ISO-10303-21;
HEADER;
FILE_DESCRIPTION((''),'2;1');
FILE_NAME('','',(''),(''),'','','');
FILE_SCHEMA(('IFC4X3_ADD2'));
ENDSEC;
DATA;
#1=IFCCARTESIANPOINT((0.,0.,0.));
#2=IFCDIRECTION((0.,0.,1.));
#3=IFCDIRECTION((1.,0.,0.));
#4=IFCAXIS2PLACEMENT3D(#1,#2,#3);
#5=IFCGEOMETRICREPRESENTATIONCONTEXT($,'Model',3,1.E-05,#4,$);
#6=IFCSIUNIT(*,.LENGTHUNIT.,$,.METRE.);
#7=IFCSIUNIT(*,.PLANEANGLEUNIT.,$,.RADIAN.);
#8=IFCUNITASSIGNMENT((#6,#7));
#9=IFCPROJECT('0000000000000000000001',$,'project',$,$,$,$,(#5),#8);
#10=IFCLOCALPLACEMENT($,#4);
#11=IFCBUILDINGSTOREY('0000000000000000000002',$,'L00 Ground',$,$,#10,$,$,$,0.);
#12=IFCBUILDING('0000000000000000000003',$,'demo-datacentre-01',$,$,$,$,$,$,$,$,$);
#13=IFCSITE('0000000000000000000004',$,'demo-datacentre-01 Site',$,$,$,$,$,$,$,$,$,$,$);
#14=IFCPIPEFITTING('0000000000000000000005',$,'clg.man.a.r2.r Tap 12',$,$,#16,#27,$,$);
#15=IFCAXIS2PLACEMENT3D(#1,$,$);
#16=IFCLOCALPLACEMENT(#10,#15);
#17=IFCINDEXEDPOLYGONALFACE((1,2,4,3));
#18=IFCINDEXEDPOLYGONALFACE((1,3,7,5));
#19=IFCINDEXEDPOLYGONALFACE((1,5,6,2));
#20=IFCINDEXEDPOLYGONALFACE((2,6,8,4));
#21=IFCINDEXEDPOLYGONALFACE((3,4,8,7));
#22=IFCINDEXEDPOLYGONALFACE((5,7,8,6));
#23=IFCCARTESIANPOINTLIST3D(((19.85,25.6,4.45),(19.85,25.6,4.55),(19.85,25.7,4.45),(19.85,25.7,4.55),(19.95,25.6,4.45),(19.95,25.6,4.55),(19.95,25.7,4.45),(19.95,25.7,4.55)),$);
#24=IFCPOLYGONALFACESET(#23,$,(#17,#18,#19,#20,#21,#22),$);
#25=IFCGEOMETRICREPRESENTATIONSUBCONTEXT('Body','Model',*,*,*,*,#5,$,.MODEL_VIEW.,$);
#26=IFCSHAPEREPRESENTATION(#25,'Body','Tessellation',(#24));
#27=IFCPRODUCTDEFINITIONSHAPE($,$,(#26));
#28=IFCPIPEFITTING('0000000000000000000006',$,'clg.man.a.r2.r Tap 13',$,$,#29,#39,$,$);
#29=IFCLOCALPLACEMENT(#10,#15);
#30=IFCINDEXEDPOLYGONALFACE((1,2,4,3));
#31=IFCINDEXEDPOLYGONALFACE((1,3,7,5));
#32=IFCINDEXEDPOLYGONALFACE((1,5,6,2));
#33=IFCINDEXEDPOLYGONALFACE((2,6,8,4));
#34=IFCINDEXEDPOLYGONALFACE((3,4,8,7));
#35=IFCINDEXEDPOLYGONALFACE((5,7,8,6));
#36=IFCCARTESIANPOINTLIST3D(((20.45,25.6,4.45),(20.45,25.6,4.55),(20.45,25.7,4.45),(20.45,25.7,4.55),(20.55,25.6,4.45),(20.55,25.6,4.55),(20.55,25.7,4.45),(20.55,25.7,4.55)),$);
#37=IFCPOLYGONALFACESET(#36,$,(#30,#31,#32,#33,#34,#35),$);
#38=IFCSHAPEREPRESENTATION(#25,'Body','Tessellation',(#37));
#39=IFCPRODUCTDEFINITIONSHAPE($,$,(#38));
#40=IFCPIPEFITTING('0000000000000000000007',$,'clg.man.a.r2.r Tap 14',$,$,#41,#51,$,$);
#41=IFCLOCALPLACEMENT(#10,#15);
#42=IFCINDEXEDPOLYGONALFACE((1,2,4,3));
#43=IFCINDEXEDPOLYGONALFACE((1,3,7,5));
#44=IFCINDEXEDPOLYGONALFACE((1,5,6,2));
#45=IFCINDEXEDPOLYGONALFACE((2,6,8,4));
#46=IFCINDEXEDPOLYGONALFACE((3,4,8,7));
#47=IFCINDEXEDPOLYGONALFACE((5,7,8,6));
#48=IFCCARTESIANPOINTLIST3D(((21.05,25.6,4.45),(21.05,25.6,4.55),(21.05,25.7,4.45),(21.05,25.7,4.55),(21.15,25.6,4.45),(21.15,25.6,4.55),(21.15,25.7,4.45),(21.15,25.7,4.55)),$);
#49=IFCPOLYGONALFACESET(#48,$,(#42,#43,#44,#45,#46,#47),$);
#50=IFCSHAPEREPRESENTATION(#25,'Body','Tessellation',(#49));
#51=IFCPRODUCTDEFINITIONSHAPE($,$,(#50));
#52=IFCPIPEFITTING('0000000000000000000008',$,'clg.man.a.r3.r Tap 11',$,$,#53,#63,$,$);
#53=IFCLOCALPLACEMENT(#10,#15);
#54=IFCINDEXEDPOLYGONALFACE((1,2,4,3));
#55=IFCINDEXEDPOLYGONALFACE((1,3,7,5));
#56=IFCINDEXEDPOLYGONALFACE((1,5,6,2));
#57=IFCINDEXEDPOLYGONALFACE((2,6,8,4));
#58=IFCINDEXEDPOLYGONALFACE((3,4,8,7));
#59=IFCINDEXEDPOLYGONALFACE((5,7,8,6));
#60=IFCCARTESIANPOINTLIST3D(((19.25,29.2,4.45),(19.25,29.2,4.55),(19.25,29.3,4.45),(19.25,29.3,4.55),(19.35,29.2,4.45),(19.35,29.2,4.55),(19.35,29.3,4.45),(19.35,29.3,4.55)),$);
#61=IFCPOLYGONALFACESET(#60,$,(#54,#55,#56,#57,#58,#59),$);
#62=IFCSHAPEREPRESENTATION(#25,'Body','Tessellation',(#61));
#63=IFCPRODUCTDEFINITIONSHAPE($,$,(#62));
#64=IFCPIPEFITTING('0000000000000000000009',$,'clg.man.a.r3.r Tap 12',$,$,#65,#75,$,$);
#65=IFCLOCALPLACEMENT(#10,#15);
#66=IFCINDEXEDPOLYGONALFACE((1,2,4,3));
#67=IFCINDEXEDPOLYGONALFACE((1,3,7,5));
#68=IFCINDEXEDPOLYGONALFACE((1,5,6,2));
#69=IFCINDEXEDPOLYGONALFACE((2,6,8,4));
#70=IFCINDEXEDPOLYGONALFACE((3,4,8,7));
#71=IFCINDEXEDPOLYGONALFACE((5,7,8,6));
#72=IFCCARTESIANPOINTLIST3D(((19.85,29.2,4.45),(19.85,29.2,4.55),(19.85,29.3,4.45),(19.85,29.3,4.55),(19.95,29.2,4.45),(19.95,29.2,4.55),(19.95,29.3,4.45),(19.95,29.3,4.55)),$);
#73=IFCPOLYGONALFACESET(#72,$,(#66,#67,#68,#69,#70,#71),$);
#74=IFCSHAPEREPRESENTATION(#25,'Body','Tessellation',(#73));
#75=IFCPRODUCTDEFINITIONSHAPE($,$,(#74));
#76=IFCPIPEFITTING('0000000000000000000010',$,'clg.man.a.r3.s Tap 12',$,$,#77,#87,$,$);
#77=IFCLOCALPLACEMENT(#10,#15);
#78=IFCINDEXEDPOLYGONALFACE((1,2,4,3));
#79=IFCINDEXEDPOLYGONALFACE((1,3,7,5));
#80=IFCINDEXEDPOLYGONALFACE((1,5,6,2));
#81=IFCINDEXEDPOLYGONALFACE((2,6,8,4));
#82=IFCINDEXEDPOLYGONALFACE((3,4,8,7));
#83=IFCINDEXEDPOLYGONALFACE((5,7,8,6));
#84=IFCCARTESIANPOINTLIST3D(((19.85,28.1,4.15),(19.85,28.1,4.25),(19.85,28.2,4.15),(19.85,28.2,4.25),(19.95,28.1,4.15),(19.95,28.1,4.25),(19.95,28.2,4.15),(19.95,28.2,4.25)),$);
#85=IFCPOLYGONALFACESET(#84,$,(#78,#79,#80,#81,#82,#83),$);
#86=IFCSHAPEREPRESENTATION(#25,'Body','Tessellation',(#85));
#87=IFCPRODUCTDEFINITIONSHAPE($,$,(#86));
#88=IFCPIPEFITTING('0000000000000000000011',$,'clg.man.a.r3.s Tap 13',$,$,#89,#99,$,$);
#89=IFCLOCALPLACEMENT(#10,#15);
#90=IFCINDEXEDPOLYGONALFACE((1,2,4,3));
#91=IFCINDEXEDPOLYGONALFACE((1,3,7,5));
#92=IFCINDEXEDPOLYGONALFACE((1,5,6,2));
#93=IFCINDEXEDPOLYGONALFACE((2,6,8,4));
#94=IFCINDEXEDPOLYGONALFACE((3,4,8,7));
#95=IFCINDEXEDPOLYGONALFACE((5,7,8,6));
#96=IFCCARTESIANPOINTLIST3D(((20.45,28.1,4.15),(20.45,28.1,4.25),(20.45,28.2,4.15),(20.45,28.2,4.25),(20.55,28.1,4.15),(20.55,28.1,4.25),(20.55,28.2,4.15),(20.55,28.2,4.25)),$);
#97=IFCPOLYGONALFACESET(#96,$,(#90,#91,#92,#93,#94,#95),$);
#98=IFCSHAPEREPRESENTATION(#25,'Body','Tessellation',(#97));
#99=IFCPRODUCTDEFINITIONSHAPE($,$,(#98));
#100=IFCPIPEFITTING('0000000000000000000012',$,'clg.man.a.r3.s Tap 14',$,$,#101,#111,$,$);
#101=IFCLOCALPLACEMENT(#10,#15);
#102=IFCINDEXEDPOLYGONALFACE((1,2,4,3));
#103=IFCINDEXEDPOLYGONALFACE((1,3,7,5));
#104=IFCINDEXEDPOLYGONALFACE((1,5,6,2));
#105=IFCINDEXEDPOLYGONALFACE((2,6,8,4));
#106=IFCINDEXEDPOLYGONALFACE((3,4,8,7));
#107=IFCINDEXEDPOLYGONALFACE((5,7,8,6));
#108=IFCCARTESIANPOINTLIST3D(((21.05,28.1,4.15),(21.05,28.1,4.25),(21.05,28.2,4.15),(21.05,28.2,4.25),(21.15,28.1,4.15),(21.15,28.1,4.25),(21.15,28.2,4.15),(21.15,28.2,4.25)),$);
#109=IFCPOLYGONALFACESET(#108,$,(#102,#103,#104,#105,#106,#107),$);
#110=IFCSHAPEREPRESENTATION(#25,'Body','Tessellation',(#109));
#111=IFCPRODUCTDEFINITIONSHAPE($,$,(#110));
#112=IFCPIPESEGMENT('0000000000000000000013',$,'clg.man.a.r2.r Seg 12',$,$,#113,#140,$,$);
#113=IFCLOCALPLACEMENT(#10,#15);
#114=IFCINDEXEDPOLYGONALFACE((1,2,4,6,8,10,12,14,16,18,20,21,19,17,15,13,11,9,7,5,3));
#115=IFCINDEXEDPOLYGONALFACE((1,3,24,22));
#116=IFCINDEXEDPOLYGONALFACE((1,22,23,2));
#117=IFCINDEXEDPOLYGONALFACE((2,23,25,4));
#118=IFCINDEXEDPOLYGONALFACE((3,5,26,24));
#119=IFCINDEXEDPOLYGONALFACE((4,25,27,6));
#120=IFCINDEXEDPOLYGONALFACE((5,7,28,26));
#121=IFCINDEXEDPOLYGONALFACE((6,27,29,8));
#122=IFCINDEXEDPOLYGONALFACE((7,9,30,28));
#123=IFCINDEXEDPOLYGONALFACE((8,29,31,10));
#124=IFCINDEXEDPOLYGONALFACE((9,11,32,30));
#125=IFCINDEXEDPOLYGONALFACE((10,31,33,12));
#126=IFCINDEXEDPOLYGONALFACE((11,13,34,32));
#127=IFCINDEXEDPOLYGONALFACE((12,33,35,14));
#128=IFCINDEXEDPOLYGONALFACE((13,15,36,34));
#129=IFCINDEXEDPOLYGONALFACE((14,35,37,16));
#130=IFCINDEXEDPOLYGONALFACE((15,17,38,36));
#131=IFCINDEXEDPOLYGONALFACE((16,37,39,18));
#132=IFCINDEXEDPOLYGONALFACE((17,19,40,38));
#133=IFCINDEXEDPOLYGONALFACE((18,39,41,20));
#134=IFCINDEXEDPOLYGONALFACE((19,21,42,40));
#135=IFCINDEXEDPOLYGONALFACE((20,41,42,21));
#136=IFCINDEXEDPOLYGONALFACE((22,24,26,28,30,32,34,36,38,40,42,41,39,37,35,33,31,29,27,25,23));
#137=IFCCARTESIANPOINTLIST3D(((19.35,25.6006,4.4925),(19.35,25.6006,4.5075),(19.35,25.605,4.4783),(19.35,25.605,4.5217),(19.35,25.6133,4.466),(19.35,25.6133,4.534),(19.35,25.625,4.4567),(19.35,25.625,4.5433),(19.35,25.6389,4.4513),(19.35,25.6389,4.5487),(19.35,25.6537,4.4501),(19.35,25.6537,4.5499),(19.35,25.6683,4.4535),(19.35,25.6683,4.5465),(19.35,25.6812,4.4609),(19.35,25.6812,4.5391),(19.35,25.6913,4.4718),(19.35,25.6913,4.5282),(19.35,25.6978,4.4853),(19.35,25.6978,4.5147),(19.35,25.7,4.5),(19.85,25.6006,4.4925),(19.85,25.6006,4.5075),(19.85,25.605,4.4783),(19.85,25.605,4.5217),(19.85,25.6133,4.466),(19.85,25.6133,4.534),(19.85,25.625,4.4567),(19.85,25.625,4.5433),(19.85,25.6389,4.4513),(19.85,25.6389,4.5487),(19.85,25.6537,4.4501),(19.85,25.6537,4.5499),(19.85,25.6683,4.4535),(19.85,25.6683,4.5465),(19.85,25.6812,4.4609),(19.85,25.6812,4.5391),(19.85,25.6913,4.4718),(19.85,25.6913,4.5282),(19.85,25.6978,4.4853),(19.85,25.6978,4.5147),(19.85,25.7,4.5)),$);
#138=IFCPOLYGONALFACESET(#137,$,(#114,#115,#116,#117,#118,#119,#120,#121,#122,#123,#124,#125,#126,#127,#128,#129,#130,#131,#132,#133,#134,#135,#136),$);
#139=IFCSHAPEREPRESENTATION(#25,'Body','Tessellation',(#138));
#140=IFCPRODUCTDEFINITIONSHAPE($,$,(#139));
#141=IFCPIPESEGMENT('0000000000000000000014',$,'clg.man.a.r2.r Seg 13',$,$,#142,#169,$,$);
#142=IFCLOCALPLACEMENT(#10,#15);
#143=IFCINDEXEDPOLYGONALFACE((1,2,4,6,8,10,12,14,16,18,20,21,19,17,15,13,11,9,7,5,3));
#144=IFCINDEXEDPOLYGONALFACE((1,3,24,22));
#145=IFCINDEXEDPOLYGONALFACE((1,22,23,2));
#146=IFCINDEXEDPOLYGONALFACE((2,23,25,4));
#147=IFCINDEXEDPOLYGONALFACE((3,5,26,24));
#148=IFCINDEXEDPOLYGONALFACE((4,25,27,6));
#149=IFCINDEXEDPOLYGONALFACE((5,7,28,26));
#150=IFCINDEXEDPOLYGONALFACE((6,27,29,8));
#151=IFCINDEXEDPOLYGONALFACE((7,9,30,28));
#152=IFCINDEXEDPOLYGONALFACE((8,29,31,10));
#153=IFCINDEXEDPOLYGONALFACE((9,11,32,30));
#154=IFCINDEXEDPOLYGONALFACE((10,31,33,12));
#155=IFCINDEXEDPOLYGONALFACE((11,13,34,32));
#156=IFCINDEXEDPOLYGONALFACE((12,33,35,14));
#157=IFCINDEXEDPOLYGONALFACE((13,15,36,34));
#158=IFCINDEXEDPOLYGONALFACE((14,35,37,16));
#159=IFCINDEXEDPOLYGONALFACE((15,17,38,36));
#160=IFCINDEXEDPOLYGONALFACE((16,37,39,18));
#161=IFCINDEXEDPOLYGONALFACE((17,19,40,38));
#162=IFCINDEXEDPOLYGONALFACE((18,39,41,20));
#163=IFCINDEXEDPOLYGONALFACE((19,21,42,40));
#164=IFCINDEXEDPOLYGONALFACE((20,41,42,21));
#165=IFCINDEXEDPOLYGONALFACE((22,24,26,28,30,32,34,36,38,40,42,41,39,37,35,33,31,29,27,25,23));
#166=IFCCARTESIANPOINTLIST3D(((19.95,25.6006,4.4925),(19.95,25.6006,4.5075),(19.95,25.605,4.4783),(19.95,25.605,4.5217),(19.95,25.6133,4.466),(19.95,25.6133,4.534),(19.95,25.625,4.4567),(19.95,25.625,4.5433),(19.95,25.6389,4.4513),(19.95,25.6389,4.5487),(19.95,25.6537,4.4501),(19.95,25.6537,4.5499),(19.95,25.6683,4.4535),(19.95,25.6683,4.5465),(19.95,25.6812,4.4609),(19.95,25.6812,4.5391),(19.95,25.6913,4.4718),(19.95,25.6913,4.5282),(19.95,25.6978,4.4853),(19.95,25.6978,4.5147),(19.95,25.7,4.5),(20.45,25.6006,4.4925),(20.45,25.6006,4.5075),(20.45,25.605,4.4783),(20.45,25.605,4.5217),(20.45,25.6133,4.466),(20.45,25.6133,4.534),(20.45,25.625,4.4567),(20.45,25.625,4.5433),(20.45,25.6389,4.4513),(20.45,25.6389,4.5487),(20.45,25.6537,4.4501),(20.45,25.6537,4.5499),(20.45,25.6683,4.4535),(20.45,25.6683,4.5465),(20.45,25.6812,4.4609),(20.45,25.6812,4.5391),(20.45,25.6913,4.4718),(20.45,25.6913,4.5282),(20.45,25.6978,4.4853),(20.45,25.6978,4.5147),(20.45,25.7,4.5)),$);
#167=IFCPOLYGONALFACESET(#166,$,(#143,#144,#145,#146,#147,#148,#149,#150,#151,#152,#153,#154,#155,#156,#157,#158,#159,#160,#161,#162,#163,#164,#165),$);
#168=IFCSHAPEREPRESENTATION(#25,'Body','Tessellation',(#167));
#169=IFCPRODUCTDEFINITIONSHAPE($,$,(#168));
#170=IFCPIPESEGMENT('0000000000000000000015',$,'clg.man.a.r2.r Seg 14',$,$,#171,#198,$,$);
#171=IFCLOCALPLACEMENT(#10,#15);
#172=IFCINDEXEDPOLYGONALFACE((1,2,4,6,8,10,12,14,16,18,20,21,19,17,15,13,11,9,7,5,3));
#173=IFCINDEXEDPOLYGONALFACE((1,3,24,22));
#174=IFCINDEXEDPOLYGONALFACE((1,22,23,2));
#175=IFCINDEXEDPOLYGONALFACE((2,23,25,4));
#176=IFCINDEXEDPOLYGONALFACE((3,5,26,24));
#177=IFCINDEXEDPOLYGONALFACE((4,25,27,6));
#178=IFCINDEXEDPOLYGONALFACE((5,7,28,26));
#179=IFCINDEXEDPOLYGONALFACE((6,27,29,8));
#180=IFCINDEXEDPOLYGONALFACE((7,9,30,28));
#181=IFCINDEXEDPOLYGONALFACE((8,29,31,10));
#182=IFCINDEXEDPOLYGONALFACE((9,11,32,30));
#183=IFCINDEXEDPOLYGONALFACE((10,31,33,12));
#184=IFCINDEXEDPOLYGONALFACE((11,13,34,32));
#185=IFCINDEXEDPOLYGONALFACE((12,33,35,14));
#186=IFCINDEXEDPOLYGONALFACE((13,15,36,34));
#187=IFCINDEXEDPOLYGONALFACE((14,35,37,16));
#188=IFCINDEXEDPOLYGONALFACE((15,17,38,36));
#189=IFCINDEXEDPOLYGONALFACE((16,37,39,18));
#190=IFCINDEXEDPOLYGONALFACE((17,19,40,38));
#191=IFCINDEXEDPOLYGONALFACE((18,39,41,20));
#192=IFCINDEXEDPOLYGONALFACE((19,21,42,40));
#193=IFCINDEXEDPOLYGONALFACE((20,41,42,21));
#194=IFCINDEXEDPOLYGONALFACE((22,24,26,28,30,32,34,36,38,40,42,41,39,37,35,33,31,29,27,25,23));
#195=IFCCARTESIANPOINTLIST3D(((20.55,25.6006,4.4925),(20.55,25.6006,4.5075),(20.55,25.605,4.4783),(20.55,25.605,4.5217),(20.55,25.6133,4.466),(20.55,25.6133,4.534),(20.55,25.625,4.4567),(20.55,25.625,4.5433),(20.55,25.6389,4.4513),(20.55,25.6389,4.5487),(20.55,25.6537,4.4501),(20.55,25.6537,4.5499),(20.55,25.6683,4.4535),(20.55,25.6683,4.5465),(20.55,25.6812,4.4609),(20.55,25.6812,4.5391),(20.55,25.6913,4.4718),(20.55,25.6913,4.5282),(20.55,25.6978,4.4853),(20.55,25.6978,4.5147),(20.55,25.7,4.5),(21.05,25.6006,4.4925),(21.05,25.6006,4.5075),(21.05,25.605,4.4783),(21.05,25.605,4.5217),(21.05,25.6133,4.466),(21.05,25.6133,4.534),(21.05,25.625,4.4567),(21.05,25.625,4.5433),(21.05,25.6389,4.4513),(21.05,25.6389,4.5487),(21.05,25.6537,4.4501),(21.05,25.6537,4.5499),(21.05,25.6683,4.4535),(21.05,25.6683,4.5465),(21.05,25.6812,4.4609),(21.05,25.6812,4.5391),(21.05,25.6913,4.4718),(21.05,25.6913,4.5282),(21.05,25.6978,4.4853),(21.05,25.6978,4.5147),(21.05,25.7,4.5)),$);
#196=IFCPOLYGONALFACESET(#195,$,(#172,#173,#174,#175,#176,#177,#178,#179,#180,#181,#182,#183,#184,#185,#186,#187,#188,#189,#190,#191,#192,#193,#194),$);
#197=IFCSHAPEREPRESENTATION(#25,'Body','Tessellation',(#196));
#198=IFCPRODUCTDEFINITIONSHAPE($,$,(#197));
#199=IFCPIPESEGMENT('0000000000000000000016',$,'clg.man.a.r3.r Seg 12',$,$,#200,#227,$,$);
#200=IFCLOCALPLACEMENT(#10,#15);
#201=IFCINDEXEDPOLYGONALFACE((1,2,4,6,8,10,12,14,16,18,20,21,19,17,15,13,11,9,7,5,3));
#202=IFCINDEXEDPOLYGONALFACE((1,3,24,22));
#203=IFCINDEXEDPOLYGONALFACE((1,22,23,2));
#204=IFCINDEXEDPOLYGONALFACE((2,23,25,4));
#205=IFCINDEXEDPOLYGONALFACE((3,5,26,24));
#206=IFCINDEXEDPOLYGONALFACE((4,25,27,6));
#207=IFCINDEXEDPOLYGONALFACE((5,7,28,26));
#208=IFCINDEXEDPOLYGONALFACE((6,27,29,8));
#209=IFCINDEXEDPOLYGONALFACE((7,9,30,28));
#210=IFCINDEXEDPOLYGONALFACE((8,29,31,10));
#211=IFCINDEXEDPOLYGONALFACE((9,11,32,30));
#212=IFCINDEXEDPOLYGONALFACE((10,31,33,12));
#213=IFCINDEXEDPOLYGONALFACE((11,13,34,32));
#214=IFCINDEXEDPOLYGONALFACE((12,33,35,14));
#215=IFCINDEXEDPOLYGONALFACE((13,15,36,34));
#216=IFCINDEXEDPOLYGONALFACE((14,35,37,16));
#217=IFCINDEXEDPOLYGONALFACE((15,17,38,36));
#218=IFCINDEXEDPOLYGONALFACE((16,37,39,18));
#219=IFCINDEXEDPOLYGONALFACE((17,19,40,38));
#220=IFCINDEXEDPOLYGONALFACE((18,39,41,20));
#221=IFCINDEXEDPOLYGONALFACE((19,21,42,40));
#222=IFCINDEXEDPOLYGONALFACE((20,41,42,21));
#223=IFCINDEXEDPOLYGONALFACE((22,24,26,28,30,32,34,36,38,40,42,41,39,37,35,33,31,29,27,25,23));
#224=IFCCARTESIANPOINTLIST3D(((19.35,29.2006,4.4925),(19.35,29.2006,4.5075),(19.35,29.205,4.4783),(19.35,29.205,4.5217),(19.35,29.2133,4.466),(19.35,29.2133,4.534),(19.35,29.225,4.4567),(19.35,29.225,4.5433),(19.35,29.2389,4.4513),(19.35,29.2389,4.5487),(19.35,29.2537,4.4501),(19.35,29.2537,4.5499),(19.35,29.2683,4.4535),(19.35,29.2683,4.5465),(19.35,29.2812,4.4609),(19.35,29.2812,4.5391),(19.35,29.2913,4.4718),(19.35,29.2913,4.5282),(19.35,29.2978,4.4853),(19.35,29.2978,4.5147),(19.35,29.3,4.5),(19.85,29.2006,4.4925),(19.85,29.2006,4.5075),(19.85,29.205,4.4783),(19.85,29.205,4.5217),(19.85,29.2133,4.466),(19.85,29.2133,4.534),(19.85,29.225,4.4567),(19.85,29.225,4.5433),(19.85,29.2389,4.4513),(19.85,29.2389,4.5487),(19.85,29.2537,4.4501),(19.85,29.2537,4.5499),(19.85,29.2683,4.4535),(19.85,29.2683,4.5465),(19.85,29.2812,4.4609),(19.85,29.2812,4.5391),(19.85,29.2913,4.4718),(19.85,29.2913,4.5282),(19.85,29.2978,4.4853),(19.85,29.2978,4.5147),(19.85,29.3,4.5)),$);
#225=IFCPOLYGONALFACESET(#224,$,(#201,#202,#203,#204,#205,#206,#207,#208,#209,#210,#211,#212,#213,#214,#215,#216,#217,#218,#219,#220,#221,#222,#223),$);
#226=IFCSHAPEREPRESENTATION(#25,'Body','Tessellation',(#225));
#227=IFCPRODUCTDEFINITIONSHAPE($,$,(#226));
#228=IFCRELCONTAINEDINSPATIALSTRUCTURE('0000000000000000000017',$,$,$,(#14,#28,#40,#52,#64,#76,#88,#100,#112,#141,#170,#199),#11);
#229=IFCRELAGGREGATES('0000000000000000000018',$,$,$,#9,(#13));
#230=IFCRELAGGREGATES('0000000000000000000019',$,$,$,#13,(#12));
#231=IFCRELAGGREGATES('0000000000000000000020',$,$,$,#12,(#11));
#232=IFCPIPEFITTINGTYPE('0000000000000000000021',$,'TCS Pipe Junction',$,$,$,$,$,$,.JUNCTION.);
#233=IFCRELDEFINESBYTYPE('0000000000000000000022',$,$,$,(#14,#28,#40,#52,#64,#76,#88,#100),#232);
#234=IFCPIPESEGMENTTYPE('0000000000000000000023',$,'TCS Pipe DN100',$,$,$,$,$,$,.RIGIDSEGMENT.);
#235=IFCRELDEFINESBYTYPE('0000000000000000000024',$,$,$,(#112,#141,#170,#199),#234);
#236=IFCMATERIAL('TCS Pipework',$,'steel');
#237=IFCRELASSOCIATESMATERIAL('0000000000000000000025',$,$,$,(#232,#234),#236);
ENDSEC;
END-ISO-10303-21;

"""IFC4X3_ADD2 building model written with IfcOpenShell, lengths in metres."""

from ifc_helpers import new_model, si_unit, frame, origin_with_axes, place, context, subcontext, project, spatial, rectangle, circle, extrude, material, type_object, element, save


model = new_model("IFC4X3_ADD2")

# Units and contexts
model_context = context("Model", 3, precision=1e-05, world=origin_with_axes())
body_context = subcontext(model_context, "Body", "Model", "MODEL_VIEW")
ifc_project = project(units=[si_unit("LENGTHUNIT", "METRE"), si_unit("PLANEANGLEUNIT", "RADIAN")], contexts=[model_context])

# Site, building, storey
site = spatial("IfcSite", under=ifc_project, Name="demo-datacentre-01 Site")
building = spatial("IfcBuilding", under=site, Name="demo-datacentre-01")
storey_placement = place(None, origin_with_axes())
storey = spatial("IfcBuildingStorey", under=building, at=storey_placement, Name="L00 Ground", Elevation=0.0)

# Pipe fittings
ifc_material = material(Name="TCS Pipework", Category="steel")
pipe_fitting_type = type_object("IfcPipeFittingType", Name="TCS Pipe Junction", PredefinedType="JUNCTION", material=ifc_material)
for number, where, z_axis, x_axis, name in (
    (1, (19.9, 25.65, 4.45), (0.0, 0.0, 1.0), (1.0, 0.0, 0.0), "clg.man.a.r2.r Tap 12"),
    (2, (20.5, 25.65, 4.45), (0.0, 0.0, 1.0), (1.0, 0.0, 0.0), "clg.man.a.r2.r Tap 13"),
    (3, (21.1, 25.65, 4.45), (0.0, 0.0, 1.0), (1.0, 0.0, 0.0), "clg.man.a.r2.r Tap 14"),
    (4, (19.3, 29.25, 4.45), (0.0, 0.0, 1.0), (1.0, 0.0, 0.0), "clg.man.a.r3.r Tap 11"),
    (5, (19.9, 29.25, 4.45), (0.0, 0.0, 1.0), (1.0, 0.0, 0.0), "clg.man.a.r3.r Tap 12"),
    (6, (19.9, 28.15, 4.15), (0.0, 0.0, 1.0), (1.0, 0.0, 0.0), "clg.man.a.r3.s Tap 12"),
    (7, (20.5, 28.15, 4.15), (0.0, 0.0, 1.0), (1.0, 0.0, 0.0), "clg.man.a.r3.s Tap 13"),
    (8, (21.1, 28.15, 4.15), (0.0, 0.0, 1.0), (1.0, 0.0, 0.0), "clg.man.a.r3.s Tap 14"),
):
    element("IfcPipeFitting", number, at=place(storey_placement, frame(where, z_axis=z_axis, x_axis=x_axis)), inside=storey, type_object=pipe_fitting_type, Name=name, context=body_context, shape_type="SweptSolid", body=[
        extrude(rectangle(XDim=0.1, YDim=0.1), origin_with_axes(), (0.0, 0.0, 1.0), 0.1),
    ])

# Pipe segments
pipe_segment_type_1 = type_object("IfcPipeSegmentType", Name="TCS Pipe DN100", PredefinedType="RIGIDSEGMENT", material=ifc_material)
pipe_segment_placement = place(storey_placement, frame((19.35, 25.65, 4.5), z_axis=(1.0, 0.0, 0.0), x_axis=(0.0, 1.0, 0.0)))
element("IfcPipeSegment", 9, at=pipe_segment_placement, inside=storey, type_object=pipe_segment_type_1, Name="clg.man.a.r2.r Seg 12", context=body_context, shape_type="SweptSolid", body=[
    extrude(circle(Radius=0.05), origin_with_axes(), (0.0, 0.0, 1.0), 0.5),
])
for number, where, z_axis, x_axis, name in (
    (10, (19.95, 25.65, 4.5), (1.0, 0.0, 0.0), (0.0, 1.0, 0.0), "clg.man.a.r2.r Seg 13"),
    (11, (20.55, 25.65, 4.5), (1.0, 0.0, 0.0), (0.0, 1.0, 0.0), "clg.man.a.r2.r Seg 14"),
):
    element("IfcPipeSegment", number, at=place(storey_placement, frame(where, z_axis=z_axis, x_axis=x_axis)), inside=storey, type_object=pipe_segment_type_1, Name=name, context=body_context, shape_type="SweptSolid", body=[
        extrude(circle(Radius=0.05), origin_with_axes(), (0.0, 0.0, 1.0), 0.5),
    ])
for number, where, z_axis, x_axis, name in (
    (12, (19.35, 29.25, 4.5), (1.0, 0.0, 0.0), (0.0, 1.0, 0.0), "clg.man.a.r3.r Seg 12"),
):
    element("IfcPipeSegment", number, at=place(storey_placement, frame(where, z_axis=z_axis, x_axis=x_axis)), inside=storey, type_object=pipe_segment_type_1, Name=name, context=body_context, shape_type="SweptSolid", body=[
        extrude(circle(Radius=0.05), origin_with_axes(), (0.0, 0.0, 1.0), 0.5),
    ])

save(model, "model.ifc")
